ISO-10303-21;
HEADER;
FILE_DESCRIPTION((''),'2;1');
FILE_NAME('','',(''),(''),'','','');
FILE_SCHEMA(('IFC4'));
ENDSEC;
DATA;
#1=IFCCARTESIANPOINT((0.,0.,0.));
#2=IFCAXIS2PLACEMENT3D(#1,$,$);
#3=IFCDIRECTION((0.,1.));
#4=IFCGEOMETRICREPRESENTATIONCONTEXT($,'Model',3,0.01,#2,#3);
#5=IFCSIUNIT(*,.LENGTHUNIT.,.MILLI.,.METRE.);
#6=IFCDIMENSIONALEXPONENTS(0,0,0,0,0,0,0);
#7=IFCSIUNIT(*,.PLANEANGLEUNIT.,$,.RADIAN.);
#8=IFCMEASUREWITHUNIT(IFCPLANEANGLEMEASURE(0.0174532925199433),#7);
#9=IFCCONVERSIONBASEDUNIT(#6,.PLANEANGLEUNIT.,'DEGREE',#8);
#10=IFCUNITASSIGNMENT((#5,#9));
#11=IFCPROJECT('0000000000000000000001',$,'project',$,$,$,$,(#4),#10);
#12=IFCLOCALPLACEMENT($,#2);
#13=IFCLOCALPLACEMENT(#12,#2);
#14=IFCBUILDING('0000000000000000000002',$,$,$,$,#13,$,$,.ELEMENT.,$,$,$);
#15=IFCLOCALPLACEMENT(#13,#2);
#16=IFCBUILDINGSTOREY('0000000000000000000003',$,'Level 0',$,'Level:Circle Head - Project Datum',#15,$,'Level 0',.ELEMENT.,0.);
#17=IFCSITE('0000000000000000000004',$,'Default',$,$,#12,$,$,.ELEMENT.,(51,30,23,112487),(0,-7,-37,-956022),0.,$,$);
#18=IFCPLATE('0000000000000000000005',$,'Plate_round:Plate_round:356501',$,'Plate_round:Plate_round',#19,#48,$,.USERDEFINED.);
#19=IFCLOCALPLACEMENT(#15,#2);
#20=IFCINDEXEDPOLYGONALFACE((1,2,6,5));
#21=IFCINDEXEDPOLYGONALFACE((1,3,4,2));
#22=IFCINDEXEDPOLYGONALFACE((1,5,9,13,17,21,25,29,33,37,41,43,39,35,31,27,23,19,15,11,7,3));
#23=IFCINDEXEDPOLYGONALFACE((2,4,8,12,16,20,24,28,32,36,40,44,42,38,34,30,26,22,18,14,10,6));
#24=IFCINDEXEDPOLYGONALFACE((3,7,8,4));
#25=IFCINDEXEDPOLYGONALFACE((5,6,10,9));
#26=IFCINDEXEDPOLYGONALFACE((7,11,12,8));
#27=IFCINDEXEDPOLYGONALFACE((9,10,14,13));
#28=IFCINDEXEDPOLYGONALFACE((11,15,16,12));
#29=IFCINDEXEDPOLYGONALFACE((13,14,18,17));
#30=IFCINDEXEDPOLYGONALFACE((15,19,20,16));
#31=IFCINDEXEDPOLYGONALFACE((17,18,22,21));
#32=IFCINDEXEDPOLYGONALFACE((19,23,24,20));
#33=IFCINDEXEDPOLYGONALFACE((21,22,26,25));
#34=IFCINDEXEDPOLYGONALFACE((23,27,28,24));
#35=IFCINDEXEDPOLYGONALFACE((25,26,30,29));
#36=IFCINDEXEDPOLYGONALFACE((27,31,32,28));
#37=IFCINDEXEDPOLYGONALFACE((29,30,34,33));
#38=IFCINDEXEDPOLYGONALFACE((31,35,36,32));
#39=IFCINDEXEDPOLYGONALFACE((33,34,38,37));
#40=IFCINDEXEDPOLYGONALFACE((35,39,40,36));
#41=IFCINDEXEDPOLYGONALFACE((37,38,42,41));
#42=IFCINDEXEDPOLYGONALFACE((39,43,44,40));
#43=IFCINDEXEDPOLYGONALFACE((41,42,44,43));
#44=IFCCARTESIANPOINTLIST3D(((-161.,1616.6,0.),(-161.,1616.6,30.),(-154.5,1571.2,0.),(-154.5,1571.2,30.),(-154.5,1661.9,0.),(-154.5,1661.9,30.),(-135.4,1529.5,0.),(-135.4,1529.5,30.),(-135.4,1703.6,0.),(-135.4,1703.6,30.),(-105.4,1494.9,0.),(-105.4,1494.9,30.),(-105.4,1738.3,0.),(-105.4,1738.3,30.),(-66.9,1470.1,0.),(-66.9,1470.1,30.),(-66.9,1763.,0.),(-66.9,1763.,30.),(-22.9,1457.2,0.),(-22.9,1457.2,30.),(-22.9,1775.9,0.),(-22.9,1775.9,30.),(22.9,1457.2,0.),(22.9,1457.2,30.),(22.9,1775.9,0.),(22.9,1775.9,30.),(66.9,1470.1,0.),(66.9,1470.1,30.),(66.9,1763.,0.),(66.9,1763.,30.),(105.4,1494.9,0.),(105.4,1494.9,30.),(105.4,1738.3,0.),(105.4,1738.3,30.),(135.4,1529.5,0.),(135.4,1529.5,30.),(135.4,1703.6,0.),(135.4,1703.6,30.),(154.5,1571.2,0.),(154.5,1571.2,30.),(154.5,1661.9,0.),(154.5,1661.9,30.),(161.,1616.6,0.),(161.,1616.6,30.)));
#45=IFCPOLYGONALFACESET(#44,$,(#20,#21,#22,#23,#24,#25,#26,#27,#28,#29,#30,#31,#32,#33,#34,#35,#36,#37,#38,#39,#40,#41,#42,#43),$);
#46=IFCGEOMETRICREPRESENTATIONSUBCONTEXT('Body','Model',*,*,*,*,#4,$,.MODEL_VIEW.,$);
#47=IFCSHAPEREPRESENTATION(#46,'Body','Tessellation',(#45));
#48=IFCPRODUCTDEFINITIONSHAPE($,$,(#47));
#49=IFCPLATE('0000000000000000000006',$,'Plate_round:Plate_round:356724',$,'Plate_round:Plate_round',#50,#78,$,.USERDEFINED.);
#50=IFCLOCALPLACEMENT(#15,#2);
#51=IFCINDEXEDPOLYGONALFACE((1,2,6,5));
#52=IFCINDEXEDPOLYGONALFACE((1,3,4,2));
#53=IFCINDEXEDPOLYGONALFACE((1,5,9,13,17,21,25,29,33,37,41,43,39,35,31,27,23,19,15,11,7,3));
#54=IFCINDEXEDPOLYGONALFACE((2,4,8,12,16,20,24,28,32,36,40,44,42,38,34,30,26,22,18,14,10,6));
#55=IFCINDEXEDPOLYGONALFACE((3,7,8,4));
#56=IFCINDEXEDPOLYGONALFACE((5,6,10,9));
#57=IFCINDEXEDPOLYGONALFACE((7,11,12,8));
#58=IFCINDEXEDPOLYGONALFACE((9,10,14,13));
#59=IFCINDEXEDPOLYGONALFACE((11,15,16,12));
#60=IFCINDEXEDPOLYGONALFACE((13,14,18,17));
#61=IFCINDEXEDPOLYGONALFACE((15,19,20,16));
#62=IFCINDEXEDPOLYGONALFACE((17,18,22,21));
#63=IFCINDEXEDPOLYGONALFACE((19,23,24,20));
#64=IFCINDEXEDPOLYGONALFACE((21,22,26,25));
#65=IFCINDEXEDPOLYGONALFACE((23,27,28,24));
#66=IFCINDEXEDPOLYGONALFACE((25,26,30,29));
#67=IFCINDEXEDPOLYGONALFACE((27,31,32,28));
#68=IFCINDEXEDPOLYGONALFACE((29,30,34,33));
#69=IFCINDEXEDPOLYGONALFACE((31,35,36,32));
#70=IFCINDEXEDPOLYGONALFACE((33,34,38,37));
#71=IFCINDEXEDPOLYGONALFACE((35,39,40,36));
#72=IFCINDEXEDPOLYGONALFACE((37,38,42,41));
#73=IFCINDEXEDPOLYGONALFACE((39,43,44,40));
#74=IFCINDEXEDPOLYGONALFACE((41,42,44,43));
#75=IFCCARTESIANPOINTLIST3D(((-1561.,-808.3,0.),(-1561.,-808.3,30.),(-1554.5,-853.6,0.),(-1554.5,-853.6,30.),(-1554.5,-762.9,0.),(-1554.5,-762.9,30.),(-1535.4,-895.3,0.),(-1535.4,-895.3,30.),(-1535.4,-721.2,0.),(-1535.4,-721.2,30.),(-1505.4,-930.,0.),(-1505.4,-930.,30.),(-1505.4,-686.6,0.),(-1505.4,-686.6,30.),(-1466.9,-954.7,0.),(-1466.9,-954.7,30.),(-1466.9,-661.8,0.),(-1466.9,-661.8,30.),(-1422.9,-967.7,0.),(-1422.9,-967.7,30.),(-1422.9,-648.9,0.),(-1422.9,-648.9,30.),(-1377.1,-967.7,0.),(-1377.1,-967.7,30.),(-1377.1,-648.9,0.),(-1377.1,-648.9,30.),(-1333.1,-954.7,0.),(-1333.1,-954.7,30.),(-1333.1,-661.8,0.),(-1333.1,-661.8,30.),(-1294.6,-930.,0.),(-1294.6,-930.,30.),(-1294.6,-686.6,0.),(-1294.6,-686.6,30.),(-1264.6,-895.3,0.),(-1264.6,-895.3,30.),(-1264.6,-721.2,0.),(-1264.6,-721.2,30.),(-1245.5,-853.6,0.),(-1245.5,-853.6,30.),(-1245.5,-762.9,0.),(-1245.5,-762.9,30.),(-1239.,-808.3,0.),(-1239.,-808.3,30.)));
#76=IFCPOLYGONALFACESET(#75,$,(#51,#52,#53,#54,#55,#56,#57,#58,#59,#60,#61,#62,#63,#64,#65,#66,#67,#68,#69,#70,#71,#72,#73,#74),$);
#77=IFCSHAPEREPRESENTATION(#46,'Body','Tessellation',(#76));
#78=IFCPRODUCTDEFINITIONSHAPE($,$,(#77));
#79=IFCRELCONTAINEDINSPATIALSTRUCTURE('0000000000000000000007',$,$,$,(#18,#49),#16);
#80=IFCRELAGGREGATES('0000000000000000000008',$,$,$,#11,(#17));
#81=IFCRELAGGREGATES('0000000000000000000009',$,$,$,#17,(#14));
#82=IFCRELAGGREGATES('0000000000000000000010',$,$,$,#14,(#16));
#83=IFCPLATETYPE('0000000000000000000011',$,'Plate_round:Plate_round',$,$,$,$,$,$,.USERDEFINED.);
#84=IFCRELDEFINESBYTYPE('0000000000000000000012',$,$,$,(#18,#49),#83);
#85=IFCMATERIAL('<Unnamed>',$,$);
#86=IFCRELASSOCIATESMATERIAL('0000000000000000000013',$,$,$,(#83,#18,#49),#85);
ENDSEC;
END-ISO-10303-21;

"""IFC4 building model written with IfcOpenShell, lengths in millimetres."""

from ifc_helpers import new_model, entity, si_unit, converted_unit, direction, frame, origin, place, context, subcontext, project, spatial, arc, indexed_curve, outline, extrude, source, transform, mapped, material, type_object, type_shapes, element, save


model = new_model("IFC4")

# Units and contexts
model_context = context("Model", 3, precision=0.01, world=origin(), true_north=direction((0.0, 1.0)))
body_context = subcontext(model_context, "Body", "Model", "MODEL_VIEW")
ifc_project = project(units=[si_unit("LENGTHUNIT", "METRE", prefix="MILLI"), converted_unit("PLANEANGLEUNIT", "DEGREE", entity("IfcPlaneAngleMeasure", 0.0174532925199433), si_unit("PLANEANGLEUNIT", "RADIAN"), dimensions=[0, 0, 0, 0, 0, 0, 0])], contexts=[model_context])

# Site, building, storey
site_placement = place(None, origin())
site = spatial("IfcSite", under=ifc_project, at=site_placement, Name="Default", CompositionType="ELEMENT", RefLatitude=(51, 30, 23, 112487), RefLongitude=(0, -7, -37, -956022), RefElevation=0.0)
building_placement = place(site_placement, origin())
building = spatial("IfcBuilding", under=site, at=building_placement, CompositionType="ELEMENT")
storey_placement = place(building_placement, origin())
storey = spatial("IfcBuildingStorey", under=building, at=storey_placement, Name="Level 0", ObjectType="Level:Circle Head - Project Datum", LongName="Level 0", CompositionType="ELEMENT", Elevation=0.0)

# Plates
ifc_material_1 = material(Name="<Unnamed>")
plate_type = type_object("IfcPlateType", Name="Plate_round:Plate_round", PredefinedType="USERDEFINED", material=ifc_material_1)
shared_shape_1 = source(origin(), body_context, "Body", "SweptSolid", [
    extrude(outline(indexed_curve([(-161.0, 0.0), (0.0, -161.0), (161.0, 0.0), (0.0, 161.0)], segments=[arc(1, 2, 3), arc(3, 4, 1)], self_intersect=False)), origin(), (0.0, 0.0, 1.0), 30.0),
])
type_shapes(plate_type, [shared_shape_1])
for number, where, name in (
    (1, (0.0, 1616.6, 0.0), "Plate_round:Plate_round:356501"),
    (2, (-1400.0, -808.3, 0.0), "Plate_round:Plate_round:356724"),
):
    element("IfcPlate", number, at=place(storey_placement, frame(where)), inside=storey, type_object=plate_type, material=ifc_material_1, Name=name, ObjectType="Plate_round:Plate_round", PredefinedType="USERDEFINED", context=body_context, shape_type="MappedRepresentation", body=[
        mapped(shared_shape_1, transform((0.0, 0.0, 0.0), scale=1.0)),
    ])

save(model, "model.ifc")
